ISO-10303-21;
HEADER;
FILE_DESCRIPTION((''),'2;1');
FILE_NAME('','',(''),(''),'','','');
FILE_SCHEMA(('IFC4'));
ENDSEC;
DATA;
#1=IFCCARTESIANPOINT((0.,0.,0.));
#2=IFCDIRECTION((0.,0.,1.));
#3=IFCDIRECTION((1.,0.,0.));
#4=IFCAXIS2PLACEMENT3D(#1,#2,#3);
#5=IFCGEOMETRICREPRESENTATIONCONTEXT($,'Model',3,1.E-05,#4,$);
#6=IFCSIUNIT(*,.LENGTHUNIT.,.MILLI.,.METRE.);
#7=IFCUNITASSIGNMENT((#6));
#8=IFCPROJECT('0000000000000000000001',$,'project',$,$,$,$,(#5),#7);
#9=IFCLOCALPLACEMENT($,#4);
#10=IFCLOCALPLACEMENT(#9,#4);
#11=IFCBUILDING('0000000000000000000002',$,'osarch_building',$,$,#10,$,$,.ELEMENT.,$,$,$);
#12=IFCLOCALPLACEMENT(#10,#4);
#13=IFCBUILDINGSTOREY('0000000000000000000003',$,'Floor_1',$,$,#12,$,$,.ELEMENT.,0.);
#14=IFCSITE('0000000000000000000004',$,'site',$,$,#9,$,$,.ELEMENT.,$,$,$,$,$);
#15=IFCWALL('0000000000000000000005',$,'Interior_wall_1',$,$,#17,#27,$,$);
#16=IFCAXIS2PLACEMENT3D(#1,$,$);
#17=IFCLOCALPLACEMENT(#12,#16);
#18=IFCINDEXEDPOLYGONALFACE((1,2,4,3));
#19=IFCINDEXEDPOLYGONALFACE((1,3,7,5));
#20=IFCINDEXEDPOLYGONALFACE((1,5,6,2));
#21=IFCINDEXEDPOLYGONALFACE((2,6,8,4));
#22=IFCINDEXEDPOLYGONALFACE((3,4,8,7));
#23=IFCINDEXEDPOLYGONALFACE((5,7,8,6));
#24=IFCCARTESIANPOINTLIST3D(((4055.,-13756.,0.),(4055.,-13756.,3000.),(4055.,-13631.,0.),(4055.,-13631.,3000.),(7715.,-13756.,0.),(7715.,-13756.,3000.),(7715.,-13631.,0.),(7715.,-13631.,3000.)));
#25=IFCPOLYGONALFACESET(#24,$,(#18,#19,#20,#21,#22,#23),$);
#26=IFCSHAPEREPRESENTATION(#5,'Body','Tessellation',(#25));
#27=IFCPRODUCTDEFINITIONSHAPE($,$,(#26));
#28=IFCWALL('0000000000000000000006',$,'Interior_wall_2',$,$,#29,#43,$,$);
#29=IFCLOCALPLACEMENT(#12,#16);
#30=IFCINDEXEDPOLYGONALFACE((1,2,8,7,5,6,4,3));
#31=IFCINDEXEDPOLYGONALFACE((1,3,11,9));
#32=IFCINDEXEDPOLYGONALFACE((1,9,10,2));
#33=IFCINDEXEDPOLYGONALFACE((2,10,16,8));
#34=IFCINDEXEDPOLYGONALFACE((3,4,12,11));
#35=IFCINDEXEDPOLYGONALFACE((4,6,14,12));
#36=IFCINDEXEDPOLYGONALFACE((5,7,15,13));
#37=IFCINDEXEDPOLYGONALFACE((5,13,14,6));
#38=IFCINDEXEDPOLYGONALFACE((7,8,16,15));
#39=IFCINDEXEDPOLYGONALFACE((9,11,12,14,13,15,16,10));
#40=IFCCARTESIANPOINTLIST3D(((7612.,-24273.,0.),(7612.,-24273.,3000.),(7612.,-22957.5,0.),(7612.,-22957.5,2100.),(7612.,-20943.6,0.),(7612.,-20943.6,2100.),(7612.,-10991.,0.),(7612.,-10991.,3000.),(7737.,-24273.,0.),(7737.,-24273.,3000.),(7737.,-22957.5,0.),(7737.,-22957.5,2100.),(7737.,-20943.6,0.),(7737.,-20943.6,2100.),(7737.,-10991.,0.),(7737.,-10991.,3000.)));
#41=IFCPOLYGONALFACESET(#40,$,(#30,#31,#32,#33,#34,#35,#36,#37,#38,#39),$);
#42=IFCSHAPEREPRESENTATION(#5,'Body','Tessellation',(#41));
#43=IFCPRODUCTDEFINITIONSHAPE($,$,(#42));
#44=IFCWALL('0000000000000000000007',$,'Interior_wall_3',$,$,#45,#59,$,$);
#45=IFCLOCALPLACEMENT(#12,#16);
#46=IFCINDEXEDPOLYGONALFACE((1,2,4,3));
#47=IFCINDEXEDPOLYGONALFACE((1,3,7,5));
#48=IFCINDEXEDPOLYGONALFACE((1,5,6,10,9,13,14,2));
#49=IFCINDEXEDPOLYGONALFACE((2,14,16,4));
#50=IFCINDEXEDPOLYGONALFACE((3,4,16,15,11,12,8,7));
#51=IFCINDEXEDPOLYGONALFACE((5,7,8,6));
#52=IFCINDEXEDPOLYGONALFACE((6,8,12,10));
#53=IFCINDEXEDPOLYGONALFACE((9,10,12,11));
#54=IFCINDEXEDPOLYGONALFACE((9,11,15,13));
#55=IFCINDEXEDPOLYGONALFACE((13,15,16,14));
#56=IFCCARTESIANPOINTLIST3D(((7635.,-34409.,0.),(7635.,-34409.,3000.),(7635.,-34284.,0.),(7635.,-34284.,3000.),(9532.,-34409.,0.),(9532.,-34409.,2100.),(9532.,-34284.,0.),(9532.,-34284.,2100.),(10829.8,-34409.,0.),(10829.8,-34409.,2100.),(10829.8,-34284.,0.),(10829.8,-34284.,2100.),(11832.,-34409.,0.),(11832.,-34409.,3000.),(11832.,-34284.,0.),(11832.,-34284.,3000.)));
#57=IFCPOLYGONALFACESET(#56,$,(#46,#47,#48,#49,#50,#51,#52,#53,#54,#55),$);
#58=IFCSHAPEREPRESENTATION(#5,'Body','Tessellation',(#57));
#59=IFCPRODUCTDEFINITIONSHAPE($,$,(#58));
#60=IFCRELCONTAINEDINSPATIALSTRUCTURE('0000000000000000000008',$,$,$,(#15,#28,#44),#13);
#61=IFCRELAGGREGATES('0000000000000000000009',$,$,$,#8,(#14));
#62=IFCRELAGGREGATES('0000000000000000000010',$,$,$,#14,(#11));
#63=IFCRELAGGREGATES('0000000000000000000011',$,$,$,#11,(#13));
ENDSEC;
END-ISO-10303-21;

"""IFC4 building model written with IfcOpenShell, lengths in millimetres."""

from ifc_helpers import new_model, si_unit, origin_with_axes, place, context, project, spatial, polyline, outline, extrude, element, save


model = new_model("IFC4")

# Units and contexts
model_context = context("Model", 3, precision=1e-05, world=origin_with_axes())
ifc_project = project(units=[si_unit("LENGTHUNIT", "METRE", prefix="MILLI")], contexts=[model_context])

# Site, building, storey
site_placement = place(None, origin_with_axes())
site = spatial("IfcSite", under=ifc_project, at=site_placement, Name="site", CompositionType="ELEMENT")
building_placement = place(site_placement, origin_with_axes())
building = spatial("IfcBuilding", under=site, at=building_placement, Name="osarch_building", CompositionType="ELEMENT")
storey_placement = place(building_placement, origin_with_axes())
storey = spatial("IfcBuildingStorey", under=building, at=storey_placement, Name="Floor_1", CompositionType="ELEMENT", Elevation=0.0)

# Wall
element("IfcWall", 1, inside=storey, Name="Interior_wall_1", context=model_context, shape_type="SweptSolid", body=[
    extrude(outline(polyline([(7715.0, -13631.0, 0.0), (7715.0, -13756.0, 0.0), (4055.0, -13756.0, 0.0), (4055.0, -13631.0, 0.0), (7715.0, -13631.0, 0.0)])), origin_with_axes(), (0.0, 0.0, 1.0), 3000.0),
])

# Walls, openings
wall_1 = element("IfcWall", 2, inside=storey, Name="Interior_wall_2", context=model_context, shape_type="SweptSolid", body=[
    extrude(outline(polyline([(7612.0, -10991.0, 0.0), (7737.0, -10991.0, 0.0), (7737.0, -24273.0, 0.0), (7612.0, -24273.0, 0.0), (7612.0, -10991.0, 0.0)])), origin_with_axes(), (0.0, 0.0, 1.0), 3000.0),
])
element("IfcOpeningElement", 3, inside=storey, cuts=wall_1, context=model_context, shape_type="SweptSolid", body=[
    extrude(outline(polyline([(6444.2, -20943.6, 0.0), (6444.2, -22957.5, 0.0), (9308.3, -22957.5, 0.0), (9308.3, -20943.6, 0.0), (6444.2, -20943.6, 0.0)])), origin_with_axes(), (0.0, 0.0, 1.0), 2100.0),
])
wall_2 = element("IfcWall", 4, inside=storey, Name="Interior_wall_3", context=model_context, shape_type="SweptSolid", body=[
    extrude(outline(polyline([(11832.0, -34284.0, 0.0), (11832.0, -34409.0, 0.0), (7635.0, -34409.0, 0.0), (7635.0, -34284.0, 0.0), (11832.0, -34284.0, 0.0)])), origin_with_axes(), (0.0, 0.0, 1.0), 3000.0),
])
element("IfcOpeningElement", 5, inside=storey, cuts=wall_2, context=model_context, shape_type="SweptSolid", body=[
    extrude(outline(polyline([(9532.0, -33518.8, 0.0), (9532.0, -35085.1, 0.0), (10829.8, -35085.1, 0.0), (10829.8, -33518.8, 0.0), (9532.0, -33518.8, 0.0)])), origin_with_axes(), (0.0, 0.0, 1.0), 2100.0),
])

save(model, "model.ifc")
